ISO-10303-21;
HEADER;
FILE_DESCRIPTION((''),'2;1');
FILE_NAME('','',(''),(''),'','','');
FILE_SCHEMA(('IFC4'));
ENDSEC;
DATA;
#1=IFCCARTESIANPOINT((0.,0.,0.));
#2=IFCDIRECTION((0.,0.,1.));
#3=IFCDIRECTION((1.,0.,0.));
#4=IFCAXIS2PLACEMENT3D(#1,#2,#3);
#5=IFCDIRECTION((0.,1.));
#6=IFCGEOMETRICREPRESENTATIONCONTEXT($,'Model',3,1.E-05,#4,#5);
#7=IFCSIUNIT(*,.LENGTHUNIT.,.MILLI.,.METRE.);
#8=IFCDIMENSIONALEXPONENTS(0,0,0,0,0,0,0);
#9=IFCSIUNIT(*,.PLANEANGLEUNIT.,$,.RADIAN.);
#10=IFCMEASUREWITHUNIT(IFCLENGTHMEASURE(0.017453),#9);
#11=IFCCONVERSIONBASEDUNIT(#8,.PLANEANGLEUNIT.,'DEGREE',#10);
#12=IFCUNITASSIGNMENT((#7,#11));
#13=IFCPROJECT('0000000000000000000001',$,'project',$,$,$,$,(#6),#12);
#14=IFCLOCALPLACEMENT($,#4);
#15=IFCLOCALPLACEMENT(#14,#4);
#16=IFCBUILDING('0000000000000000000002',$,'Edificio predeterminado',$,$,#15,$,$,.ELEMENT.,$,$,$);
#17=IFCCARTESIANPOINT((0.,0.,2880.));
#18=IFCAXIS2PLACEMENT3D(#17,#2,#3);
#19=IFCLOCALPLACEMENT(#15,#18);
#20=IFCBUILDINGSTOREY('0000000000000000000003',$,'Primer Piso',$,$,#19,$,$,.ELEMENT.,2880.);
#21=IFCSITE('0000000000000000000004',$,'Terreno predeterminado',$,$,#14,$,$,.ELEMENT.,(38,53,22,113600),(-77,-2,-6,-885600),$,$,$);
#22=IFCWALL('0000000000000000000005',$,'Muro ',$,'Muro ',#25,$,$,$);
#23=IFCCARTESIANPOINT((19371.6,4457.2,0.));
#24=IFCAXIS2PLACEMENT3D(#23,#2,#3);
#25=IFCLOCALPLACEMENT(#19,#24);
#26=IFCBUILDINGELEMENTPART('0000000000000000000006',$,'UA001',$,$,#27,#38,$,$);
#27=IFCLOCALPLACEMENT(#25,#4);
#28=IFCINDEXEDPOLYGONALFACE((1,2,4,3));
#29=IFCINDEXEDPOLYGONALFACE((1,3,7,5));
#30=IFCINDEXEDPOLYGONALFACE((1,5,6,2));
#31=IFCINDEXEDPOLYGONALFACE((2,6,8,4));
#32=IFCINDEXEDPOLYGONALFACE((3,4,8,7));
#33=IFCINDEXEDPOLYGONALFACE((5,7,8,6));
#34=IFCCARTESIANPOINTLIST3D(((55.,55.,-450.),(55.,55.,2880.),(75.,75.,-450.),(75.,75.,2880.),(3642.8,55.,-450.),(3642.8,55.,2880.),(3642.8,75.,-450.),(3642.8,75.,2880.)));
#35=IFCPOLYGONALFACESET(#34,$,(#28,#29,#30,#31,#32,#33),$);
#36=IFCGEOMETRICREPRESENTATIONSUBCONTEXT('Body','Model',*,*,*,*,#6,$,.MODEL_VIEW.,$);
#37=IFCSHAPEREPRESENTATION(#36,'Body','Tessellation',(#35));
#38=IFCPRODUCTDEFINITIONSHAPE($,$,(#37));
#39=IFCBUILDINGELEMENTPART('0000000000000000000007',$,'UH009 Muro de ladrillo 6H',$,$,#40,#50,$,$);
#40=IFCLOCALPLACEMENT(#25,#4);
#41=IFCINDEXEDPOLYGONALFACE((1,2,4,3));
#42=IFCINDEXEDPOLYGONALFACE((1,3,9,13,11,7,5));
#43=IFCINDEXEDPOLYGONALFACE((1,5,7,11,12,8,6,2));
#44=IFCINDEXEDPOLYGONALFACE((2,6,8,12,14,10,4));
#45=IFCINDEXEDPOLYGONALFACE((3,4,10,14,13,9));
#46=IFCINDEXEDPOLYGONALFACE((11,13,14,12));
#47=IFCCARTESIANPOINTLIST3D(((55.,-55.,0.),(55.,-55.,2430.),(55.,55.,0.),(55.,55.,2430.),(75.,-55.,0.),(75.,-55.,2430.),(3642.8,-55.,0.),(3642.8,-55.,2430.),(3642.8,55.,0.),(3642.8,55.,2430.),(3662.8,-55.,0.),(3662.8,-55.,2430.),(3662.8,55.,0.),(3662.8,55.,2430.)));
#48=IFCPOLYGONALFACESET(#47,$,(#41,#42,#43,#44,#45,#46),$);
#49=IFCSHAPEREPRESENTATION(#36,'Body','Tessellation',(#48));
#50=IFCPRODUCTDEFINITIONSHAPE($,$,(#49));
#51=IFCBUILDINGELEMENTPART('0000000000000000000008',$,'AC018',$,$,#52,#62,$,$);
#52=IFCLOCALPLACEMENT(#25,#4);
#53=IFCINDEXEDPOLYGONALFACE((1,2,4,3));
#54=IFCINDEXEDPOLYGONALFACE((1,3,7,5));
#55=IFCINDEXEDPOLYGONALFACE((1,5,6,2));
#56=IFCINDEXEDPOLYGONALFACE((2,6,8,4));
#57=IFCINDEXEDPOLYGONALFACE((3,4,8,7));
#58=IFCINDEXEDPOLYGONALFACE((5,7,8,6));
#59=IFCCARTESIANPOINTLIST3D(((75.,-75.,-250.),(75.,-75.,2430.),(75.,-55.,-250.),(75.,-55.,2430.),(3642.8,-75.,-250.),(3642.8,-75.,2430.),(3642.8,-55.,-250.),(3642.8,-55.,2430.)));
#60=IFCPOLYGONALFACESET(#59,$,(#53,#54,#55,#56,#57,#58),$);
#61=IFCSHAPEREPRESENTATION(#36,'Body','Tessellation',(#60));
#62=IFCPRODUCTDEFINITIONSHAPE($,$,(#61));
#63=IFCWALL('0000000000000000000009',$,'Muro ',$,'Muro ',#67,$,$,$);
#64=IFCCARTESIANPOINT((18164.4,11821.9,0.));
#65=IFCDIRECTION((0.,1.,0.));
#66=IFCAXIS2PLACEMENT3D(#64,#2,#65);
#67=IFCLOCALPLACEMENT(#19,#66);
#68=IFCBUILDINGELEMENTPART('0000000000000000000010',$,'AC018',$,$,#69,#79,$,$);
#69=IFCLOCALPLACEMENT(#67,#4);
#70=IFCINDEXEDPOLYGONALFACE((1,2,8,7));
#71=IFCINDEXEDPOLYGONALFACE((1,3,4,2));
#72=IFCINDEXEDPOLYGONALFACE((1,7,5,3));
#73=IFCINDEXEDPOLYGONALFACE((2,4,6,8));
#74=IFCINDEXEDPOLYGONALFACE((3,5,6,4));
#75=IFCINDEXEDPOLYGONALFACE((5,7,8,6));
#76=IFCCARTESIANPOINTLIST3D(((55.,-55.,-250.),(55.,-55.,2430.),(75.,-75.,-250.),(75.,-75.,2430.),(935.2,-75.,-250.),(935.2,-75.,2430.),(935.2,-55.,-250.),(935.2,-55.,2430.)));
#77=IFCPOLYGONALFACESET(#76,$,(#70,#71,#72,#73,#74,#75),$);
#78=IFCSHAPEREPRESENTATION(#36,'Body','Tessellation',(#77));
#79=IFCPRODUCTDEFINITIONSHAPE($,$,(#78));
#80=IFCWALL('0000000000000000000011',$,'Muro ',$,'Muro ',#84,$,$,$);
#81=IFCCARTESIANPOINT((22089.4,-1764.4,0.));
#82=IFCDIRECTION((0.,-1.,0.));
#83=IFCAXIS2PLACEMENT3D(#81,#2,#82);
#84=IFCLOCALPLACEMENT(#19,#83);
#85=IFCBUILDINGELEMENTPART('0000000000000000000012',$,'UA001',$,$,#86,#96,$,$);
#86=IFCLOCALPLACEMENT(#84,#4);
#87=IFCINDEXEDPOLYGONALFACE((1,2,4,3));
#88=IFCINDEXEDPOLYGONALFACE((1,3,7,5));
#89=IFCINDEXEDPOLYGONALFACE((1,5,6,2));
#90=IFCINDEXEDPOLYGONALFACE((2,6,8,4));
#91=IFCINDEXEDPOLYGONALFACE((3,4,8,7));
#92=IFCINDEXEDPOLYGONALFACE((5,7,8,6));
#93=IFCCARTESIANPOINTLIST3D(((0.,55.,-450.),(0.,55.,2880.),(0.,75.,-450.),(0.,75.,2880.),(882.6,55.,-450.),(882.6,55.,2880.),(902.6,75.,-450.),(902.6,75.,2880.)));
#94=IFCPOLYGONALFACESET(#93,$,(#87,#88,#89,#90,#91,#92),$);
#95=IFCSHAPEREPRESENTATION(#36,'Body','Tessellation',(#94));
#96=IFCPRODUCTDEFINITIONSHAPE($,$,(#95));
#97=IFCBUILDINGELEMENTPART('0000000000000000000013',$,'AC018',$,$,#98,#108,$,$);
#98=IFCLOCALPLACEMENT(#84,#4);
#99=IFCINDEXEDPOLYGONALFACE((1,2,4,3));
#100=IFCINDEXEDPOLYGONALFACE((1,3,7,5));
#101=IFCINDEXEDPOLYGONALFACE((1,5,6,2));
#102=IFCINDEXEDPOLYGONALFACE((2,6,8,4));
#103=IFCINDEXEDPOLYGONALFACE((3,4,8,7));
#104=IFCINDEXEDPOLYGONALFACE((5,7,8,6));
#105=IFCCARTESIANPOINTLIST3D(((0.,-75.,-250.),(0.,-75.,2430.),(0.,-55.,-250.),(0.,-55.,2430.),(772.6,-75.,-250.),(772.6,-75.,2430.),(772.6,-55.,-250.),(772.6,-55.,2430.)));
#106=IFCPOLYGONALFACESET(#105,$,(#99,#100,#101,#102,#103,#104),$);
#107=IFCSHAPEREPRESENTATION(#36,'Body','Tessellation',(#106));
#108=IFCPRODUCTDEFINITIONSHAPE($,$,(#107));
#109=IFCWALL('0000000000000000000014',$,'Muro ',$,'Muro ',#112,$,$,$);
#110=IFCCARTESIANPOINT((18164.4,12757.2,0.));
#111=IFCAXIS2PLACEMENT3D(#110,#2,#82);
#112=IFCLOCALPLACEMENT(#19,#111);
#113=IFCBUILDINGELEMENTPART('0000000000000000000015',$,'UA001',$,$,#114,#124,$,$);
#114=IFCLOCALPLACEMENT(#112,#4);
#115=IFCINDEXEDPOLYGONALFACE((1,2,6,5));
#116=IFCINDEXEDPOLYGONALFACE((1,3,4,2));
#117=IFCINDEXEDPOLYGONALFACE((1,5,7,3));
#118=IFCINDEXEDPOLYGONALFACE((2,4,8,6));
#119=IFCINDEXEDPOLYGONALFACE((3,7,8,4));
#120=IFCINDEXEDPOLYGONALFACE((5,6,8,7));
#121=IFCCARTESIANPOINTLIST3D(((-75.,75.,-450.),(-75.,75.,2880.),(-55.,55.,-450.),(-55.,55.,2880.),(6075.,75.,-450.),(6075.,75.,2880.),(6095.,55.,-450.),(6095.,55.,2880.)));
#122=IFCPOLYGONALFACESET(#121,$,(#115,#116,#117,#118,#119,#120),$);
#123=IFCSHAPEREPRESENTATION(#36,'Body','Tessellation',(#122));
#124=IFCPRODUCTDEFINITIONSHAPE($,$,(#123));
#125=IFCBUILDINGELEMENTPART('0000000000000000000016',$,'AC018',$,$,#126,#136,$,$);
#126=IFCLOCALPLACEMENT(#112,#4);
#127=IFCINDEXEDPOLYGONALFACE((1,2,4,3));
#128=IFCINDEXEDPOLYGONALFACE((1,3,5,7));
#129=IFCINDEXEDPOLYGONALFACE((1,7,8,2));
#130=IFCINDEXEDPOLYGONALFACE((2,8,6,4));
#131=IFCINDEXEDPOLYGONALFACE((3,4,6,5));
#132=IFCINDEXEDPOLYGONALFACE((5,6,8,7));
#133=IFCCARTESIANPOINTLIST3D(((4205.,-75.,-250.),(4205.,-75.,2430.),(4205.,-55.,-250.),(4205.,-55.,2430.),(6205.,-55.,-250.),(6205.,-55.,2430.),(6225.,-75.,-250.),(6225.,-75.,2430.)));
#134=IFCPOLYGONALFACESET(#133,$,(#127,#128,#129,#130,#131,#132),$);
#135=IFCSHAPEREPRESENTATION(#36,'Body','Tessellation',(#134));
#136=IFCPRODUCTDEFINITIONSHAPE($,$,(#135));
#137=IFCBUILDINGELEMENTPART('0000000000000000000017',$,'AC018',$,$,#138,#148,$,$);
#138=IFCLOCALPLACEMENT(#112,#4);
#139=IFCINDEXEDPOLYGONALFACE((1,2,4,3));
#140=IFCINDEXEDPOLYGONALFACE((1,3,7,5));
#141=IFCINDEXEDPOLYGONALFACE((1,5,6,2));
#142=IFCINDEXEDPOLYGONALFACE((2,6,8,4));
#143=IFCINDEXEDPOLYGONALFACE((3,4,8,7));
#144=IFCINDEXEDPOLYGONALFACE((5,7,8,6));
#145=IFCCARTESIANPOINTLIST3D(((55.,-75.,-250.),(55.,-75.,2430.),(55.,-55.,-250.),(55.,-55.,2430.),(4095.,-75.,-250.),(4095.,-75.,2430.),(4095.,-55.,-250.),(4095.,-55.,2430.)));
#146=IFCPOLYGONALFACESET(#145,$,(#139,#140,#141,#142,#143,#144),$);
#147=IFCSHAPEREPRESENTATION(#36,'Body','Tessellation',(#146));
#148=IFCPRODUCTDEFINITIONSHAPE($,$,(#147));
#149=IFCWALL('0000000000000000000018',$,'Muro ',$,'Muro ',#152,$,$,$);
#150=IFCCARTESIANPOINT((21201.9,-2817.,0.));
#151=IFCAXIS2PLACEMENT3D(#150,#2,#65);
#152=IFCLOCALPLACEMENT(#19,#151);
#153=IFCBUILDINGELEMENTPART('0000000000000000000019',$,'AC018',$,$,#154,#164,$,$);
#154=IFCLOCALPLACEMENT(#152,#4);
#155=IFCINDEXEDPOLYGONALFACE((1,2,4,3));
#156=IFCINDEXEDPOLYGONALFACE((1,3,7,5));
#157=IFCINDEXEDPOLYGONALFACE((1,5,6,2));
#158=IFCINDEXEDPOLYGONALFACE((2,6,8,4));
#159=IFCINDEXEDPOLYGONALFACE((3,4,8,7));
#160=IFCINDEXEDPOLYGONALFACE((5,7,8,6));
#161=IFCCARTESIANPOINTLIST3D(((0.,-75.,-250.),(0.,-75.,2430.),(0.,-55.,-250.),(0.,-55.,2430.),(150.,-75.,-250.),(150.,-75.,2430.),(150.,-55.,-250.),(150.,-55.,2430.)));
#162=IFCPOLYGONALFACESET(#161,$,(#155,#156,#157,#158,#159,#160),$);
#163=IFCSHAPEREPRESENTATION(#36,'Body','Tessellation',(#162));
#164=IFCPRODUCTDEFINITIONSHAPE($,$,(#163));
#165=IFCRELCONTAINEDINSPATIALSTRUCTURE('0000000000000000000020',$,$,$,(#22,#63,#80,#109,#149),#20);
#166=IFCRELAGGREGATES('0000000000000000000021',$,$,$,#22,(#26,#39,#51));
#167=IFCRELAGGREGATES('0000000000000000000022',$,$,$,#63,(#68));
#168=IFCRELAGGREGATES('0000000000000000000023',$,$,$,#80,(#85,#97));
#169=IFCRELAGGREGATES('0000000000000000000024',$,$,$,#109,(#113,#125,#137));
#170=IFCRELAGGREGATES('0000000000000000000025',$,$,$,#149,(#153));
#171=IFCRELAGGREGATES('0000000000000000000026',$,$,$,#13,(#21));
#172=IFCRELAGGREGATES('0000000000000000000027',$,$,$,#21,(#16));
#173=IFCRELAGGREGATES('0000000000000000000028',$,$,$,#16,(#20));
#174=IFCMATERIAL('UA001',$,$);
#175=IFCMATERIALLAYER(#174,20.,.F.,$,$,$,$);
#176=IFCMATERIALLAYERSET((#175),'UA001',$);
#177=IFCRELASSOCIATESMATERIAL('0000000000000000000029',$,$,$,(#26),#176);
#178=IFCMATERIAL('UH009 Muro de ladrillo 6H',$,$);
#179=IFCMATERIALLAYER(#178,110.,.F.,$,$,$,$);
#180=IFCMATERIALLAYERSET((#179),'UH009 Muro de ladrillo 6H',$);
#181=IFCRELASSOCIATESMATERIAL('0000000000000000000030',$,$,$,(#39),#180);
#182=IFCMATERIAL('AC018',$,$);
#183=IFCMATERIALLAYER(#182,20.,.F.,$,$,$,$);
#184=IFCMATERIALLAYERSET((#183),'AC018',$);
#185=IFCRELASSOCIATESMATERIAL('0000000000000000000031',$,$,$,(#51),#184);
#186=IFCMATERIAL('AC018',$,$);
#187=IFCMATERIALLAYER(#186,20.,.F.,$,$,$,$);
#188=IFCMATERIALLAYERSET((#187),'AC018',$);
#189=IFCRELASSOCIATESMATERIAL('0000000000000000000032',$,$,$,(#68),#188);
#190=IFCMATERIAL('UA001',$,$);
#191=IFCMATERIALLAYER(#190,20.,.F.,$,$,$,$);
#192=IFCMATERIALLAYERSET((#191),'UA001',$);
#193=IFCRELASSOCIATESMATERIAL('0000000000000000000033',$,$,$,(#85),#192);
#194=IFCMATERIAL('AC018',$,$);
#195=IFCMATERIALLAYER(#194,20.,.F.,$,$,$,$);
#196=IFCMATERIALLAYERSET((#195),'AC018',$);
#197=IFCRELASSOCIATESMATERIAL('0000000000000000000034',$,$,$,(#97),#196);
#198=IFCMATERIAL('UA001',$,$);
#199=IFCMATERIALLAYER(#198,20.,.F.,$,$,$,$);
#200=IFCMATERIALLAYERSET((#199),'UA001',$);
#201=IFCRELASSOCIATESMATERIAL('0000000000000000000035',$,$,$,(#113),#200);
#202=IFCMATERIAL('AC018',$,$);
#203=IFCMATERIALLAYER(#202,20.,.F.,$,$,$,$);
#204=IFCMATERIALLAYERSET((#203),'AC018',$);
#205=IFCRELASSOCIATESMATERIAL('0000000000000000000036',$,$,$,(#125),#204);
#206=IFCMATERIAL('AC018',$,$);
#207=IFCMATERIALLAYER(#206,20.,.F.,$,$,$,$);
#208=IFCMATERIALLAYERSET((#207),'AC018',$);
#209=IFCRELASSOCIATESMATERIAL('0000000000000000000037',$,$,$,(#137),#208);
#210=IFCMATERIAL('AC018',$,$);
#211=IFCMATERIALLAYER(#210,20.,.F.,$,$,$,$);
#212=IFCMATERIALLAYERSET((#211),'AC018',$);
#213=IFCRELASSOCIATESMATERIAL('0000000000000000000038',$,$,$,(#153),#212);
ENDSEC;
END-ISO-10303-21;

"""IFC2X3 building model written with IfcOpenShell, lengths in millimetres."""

from ifc_helpers import new_model, entity, si_unit, converted_unit, direction, frame, origin_with_axes, place, context, subcontext, project, spatial, polyline, outline, extrude, clip, bounded_halfspace, material, layer, layer_set, layer_usage, element, aggregate, save


model = new_model("IFC2X3")

# Units and contexts
model_context = context("Model", 3, precision=1e-05, world=origin_with_axes(), true_north=direction((0.0, 1.0)))
body_context = subcontext(model_context, "Body", "Model", "MODEL_VIEW")
ifc_project = project(units=[si_unit("LENGTHUNIT", "METRE", prefix="MILLI"), converted_unit("PLANEANGLEUNIT", "DEGREE", entity("IfcLengthMeasure", 0.017453), si_unit("PLANEANGLEUNIT", "RADIAN"), dimensions=[0, 0, 0, 0, 0, 0, 0])], contexts=[model_context])

# Site, building, storey
site_placement = place(None, origin_with_axes())
site = spatial("IfcSite", under=ifc_project, at=site_placement, Name="Terreno predeterminado", CompositionType="ELEMENT", RefLatitude=(38, 53, 22, 113600), RefLongitude=(-77, -2, -6, -885600))
building_placement = place(site_placement, origin_with_axes())
building = spatial("IfcBuilding", under=site, at=building_placement, Name="Edificio predeterminado", CompositionType="ELEMENT")
storey_placement = place(building_placement, frame((0.0, 0.0, 2880.0), z_axis=(0.0, 0.0, 1.0), x_axis=(1.0, 0.0, 0.0)))
storey = spatial("IfcBuildingStorey", under=building, at=storey_placement, Name="Primer Piso", CompositionType="ELEMENT", Elevation=2880.0)

# Walls, building element parts
wall_1_placement = place(storey_placement, frame((19371.6, 4457.2, 0.0), z_axis=(0.0, 0.0, 1.0), x_axis=(1.0, 0.0, 0.0)))
wall_1 = element("IfcWall", 1, at=wall_1_placement, inside=storey, Name="Muro ", ObjectType="Muro ")
ifc_material_1 = material(Name="UA001")
ifc_layer_1 = layer(ifc_material_1, 20.0, ventilated=False)
ifc_layer_set_1 = layer_set([ifc_layer_1], Name="UA001")
ifc_layer_usage_1 = layer_usage(ifc_layer_set_1, "AXIS2", "NEGATIVE", -75.0)
building_element_part_1_placement = place(wall_1_placement, origin_with_axes())
building_element_part_1 = element("IfcBuildingElementPart", 2, at=building_element_part_1_placement, material=ifc_layer_usage_1, Name="UA001", context=body_context, shape_type="SweptSolid", body=[
    extrude(outline(polyline([(3642.8, 75.0), (3642.8, 55.0), (55.0, 55.0), (75.0, 75.0), (3642.8, 75.0)])), frame((0.0, 0.0, -450.0), z_axis=(0.0, 0.0, 1.0), x_axis=(1.0, 0.0, 0.0)), (0.0, 0.0, 1.0), 3330.0),
])
ifc_material_2 = material(Name="UH009 Muro de ladrillo 6H")
ifc_layer_2 = layer(ifc_material_2, 110.0, ventilated=False)
ifc_layer_set_2 = layer_set([ifc_layer_2], Name="UH009 Muro de ladrillo 6H")
ifc_layer_usage_2 = layer_usage(ifc_layer_set_2, "AXIS2", "NEGATIVE", -55.0)
building_element_part_2_placement = place(wall_1_placement, origin_with_axes())
building_element_part_2 = element("IfcBuildingElementPart", 3, at=building_element_part_2_placement, material=ifc_layer_usage_2, Name="UH009 Muro de ladrillo 6H", context=body_context, shape_type="SweptSolid", body=[
    extrude(outline(polyline([(3662.8, 55.0), (3662.8, -55.0), (3642.8, -55.0), (75.0, -55.0), (55.0, -55.0), (55.0, 55.0), (3642.8, 55.0), (3662.8, 55.0)])), origin_with_axes(), (0.0, 0.0, 1.0), 2430.0),
])
ifc_material_3 = material(Name="AC018")
ifc_layer_3 = layer(ifc_material_3, 20.0, ventilated=False)
ifc_layer_set_3 = layer_set([ifc_layer_3], Name="AC018")
ifc_layer_usage_3 = layer_usage(ifc_layer_set_3, "AXIS2", "NEGATIVE", 55.0)
building_element_part_3_placement = place(wall_1_placement, origin_with_axes())
building_element_part_3 = element("IfcBuildingElementPart", 4, at=building_element_part_3_placement, material=ifc_layer_usage_3, Name="AC018", context=body_context, shape_type="SweptSolid", body=[
    extrude(outline(polyline([(3642.8, -55.0), (3642.8, -75.0), (75.0, -75.0), (75.0, -55.0), (3642.8, -55.0)])), frame((0.0, 0.0, -250.0), z_axis=(0.0, 0.0, 1.0), x_axis=(1.0, 0.0, 0.0)), (0.0, 0.0, 1.0), 2680.0),
])
aggregate(wall_1, [building_element_part_1, building_element_part_2, building_element_part_3])
wall_2_placement = place(storey_placement, frame((18164.4, 11821.9, 0.0), z_axis=(0.0, 0.0, 1.0), x_axis=(0.0, 1.0, 0.0)))
wall_2 = element("IfcWall", 5, at=wall_2_placement, inside=storey, Name="Muro ", ObjectType="Muro ")
ifc_material_4 = material(Name="AC018")
ifc_layer_4 = layer(ifc_material_4, 20.0, ventilated=False)
ifc_layer_set_4 = layer_set([ifc_layer_4], Name="AC018")
ifc_layer_usage_4 = layer_usage(ifc_layer_set_4, "AXIS2", "NEGATIVE", 55.0)
building_element_part_4_placement = place(wall_2_placement, origin_with_axes())
building_element_part_4 = element("IfcBuildingElementPart", 6, at=building_element_part_4_placement, material=ifc_layer_usage_4, Name="AC018", context=body_context, shape_type="SweptSolid", body=[
    extrude(outline(polyline([(935.2, -55.0), (935.2, -75.0), (75.0, -75.0), (55.0, -55.0), (935.2, -55.0)])), frame((0.0, 0.0, -250.0), z_axis=(0.0, 0.0, 1.0), x_axis=(1.0, 0.0, 0.0)), (0.0, 0.0, 1.0), 2680.0),
])
aggregate(wall_2, [building_element_part_4])
wall_3_placement = place(storey_placement, frame((22089.4, -1764.4, 0.0), z_axis=(0.0, 0.0, 1.0), x_axis=(0.0, -1.0, 0.0)))
wall_3 = element("IfcWall", 7, at=wall_3_placement, inside=storey, Name="Muro ", ObjectType="Muro ")
ifc_material_5 = material(Name="UA001")
ifc_layer_5 = layer(ifc_material_5, 20.0, ventilated=False)
ifc_layer_set_5 = layer_set([ifc_layer_5], Name="UA001")
ifc_layer_usage_5 = layer_usage(ifc_layer_set_5, "AXIS2", "NEGATIVE", -75.0)
building_element_part_5_placement = place(wall_3_placement, origin_with_axes())
building_element_part_5 = element("IfcBuildingElementPart", 8, at=building_element_part_5_placement, material=ifc_layer_usage_5, Name="UA001", context=body_context, shape_type="SweptSolid", body=[
    extrude(outline(polyline([(902.6, 75.0), (882.6, 55.0), (0.0, 55.0), (0.0, 75.0), (902.6, 75.0)])), frame((0.0, 0.0, -450.0), z_axis=(0.0, 0.0, 1.0), x_axis=(1.0, 0.0, 0.0)), (0.0, 0.0, 1.0), 3330.0),
])
ifc_material_6 = material(Name="AC018")
ifc_layer_6 = layer(ifc_material_6, 20.0, ventilated=False)
ifc_layer_set_6 = layer_set([ifc_layer_6], Name="AC018")
ifc_layer_usage_6 = layer_usage(ifc_layer_set_6, "AXIS2", "NEGATIVE", 55.0)
building_element_part_6_placement = place(wall_3_placement, origin_with_axes())
building_element_part_6 = element("IfcBuildingElementPart", 9, at=building_element_part_6_placement, material=ifc_layer_usage_6, Name="AC018", context=body_context, shape_type="SweptSolid", body=[
    extrude(outline(polyline([(772.6, -55.0), (772.6, -75.0), (0.0, -75.0), (0.0, -55.0), (772.6, -55.0)])), frame((0.0, 0.0, -250.0), z_axis=(0.0, 0.0, 1.0), x_axis=(1.0, 0.0, 0.0)), (0.0, 0.0, 1.0), 2680.0),
])
aggregate(wall_3, [building_element_part_5, building_element_part_6])
wall_4_placement = place(storey_placement, frame((18164.4, 12757.2, 0.0), z_axis=(0.0, 0.0, 1.0), x_axis=(0.0, -1.0, 0.0)))
wall_4 = element("IfcWall", 10, at=wall_4_placement, inside=storey, Name="Muro ", ObjectType="Muro ")
ifc_material_7 = material(Name="UA001")
ifc_layer_7 = layer(ifc_material_7, 20.0, ventilated=False)
ifc_layer_set_7 = layer_set([ifc_layer_7], Name="UA001")
ifc_layer_usage_7 = layer_usage(ifc_layer_set_7, "AXIS2", "NEGATIVE", -75.0)
building_element_part_7_placement = place(wall_4_placement, origin_with_axes())
building_element_part_7 = element("IfcBuildingElementPart", 11, at=building_element_part_7_placement, material=ifc_layer_usage_7, Name="UA001", context=body_context, shape_type="SweptSolid", body=[
    extrude(outline(polyline([(6075.0, 75.0), (6095.0, 55.0), (-55.0, 55.0), (-75.0, 75.0), (6075.0, 75.0)])), frame((0.0, 0.0, -450.0), z_axis=(0.0, 0.0, 1.0), x_axis=(1.0, 0.0, 0.0)), (0.0, 0.0, 1.0), 3330.0),
])
ifc_material_8 = material(Name="AC018")
ifc_layer_8 = layer(ifc_material_8, 20.0, ventilated=False)
ifc_layer_set_8 = layer_set([ifc_layer_8], Name="AC018")
ifc_layer_usage_8 = layer_usage(ifc_layer_set_8, "AXIS2", "NEGATIVE", 55.0)
building_element_part_8_placement = place(wall_4_placement, origin_with_axes())
building_element_part_8 = element("IfcBuildingElementPart", 12, at=building_element_part_8_placement, material=ifc_layer_usage_8, Name="AC018", context=body_context, shape_type="SweptSolid", body=[
    extrude(outline(polyline([(6205.0, -55.0), (6225.0, -75.0), (4205.0, -75.0), (4205.0, -55.0), (6205.0, -55.0)])), frame((0.0, 0.0, -250.0), z_axis=(0.0, 0.0, 1.0), x_axis=(1.0, 0.0, 0.0)), (0.0, 0.0, 1.0), 2680.0),
])
ifc_material_9 = material(Name="AC018")
ifc_layer_9 = layer(ifc_material_9, 20.0, ventilated=False)
ifc_layer_set_9 = layer_set([ifc_layer_9], Name="AC018")
ifc_layer_usage_9 = layer_usage(ifc_layer_set_9, "AXIS2", "NEGATIVE", 55.0)
building_element_part_9_placement = place(wall_4_placement, origin_with_axes())
building_element_part_9 = element("IfcBuildingElementPart", 13, at=building_element_part_9_placement, material=ifc_layer_usage_9, Name="AC018", context=body_context, shape_type="SweptSolid", body=[
    extrude(outline(polyline([(4095.0, -55.0), (4095.0, -75.0), (55.0, -75.0), (55.0, -55.0), (4095.0, -55.0)])), frame((0.0, 0.0, -250.0), z_axis=(0.0, 0.0, 1.0), x_axis=(1.0, 0.0, 0.0)), (0.0, 0.0, 1.0), 2680.0),
])
aggregate(wall_4, [building_element_part_7, building_element_part_8, building_element_part_9])
wall_5_placement = place(storey_placement, frame((21201.9, -2817.0, 0.0), z_axis=(0.0, 0.0, 1.0), x_axis=(0.0, 1.0, 0.0)))
wall_5 = element("IfcWall", 14, at=wall_5_placement, inside=storey, Name="Muro ", ObjectType="Muro ")
ifc_material_10 = material(Name="AC018")
ifc_layer_10 = layer(ifc_material_10, 20.0, ventilated=False)
ifc_layer_set_10 = layer_set([ifc_layer_10], Name="AC018")
ifc_layer_usage_10 = layer_usage(ifc_layer_set_10, "AXIS2", "NEGATIVE", 55.0)
building_element_part_10_placement = place(wall_5_placement, origin_with_axes())
building_element_part_10 = element("IfcBuildingElementPart", 15, at=building_element_part_10_placement, material=ifc_layer_usage_10, Name="AC018", context=body_context, shape_type="Clipping", body=[
    clip(clip(extrude(outline(polyline([(150.0, -55.0), (150.0, -75.0), (0.0, -75.0), (0.0, -55.0), (150.0, -55.0)])), frame((0.0, 0.0, -250.0), z_axis=(0.0, 0.0, 1.0), x_axis=(1.0, 0.0, 0.0)), (0.0, 0.0, 1.0), 2680.0), bounded_halfspace(frame((0.0, 0.0, -250.0), z_axis=(0.0, 0.0, 1.0), x_axis=(1.0, 0.0, 0.0)), True, origin_with_axes(), polyline([(-150.0, -150.0), (375.0, -150.0), (375.0, 150.0), (-150.0, 150.0), (-150.0, -150.0)]))), bounded_halfspace(frame((0.0, 0.0, 2430.0), z_axis=(0.0, 0.0, 1.0), x_axis=(1.0, 0.0, 0.0)), False, origin_with_axes(), polyline([(-150.0, -150.0), (375.0, -150.0), (375.0, 150.0), (-150.0, 150.0), (-150.0, -150.0)]))),
])
aggregate(wall_5, [building_element_part_10])

save(model, "model.ifc")
